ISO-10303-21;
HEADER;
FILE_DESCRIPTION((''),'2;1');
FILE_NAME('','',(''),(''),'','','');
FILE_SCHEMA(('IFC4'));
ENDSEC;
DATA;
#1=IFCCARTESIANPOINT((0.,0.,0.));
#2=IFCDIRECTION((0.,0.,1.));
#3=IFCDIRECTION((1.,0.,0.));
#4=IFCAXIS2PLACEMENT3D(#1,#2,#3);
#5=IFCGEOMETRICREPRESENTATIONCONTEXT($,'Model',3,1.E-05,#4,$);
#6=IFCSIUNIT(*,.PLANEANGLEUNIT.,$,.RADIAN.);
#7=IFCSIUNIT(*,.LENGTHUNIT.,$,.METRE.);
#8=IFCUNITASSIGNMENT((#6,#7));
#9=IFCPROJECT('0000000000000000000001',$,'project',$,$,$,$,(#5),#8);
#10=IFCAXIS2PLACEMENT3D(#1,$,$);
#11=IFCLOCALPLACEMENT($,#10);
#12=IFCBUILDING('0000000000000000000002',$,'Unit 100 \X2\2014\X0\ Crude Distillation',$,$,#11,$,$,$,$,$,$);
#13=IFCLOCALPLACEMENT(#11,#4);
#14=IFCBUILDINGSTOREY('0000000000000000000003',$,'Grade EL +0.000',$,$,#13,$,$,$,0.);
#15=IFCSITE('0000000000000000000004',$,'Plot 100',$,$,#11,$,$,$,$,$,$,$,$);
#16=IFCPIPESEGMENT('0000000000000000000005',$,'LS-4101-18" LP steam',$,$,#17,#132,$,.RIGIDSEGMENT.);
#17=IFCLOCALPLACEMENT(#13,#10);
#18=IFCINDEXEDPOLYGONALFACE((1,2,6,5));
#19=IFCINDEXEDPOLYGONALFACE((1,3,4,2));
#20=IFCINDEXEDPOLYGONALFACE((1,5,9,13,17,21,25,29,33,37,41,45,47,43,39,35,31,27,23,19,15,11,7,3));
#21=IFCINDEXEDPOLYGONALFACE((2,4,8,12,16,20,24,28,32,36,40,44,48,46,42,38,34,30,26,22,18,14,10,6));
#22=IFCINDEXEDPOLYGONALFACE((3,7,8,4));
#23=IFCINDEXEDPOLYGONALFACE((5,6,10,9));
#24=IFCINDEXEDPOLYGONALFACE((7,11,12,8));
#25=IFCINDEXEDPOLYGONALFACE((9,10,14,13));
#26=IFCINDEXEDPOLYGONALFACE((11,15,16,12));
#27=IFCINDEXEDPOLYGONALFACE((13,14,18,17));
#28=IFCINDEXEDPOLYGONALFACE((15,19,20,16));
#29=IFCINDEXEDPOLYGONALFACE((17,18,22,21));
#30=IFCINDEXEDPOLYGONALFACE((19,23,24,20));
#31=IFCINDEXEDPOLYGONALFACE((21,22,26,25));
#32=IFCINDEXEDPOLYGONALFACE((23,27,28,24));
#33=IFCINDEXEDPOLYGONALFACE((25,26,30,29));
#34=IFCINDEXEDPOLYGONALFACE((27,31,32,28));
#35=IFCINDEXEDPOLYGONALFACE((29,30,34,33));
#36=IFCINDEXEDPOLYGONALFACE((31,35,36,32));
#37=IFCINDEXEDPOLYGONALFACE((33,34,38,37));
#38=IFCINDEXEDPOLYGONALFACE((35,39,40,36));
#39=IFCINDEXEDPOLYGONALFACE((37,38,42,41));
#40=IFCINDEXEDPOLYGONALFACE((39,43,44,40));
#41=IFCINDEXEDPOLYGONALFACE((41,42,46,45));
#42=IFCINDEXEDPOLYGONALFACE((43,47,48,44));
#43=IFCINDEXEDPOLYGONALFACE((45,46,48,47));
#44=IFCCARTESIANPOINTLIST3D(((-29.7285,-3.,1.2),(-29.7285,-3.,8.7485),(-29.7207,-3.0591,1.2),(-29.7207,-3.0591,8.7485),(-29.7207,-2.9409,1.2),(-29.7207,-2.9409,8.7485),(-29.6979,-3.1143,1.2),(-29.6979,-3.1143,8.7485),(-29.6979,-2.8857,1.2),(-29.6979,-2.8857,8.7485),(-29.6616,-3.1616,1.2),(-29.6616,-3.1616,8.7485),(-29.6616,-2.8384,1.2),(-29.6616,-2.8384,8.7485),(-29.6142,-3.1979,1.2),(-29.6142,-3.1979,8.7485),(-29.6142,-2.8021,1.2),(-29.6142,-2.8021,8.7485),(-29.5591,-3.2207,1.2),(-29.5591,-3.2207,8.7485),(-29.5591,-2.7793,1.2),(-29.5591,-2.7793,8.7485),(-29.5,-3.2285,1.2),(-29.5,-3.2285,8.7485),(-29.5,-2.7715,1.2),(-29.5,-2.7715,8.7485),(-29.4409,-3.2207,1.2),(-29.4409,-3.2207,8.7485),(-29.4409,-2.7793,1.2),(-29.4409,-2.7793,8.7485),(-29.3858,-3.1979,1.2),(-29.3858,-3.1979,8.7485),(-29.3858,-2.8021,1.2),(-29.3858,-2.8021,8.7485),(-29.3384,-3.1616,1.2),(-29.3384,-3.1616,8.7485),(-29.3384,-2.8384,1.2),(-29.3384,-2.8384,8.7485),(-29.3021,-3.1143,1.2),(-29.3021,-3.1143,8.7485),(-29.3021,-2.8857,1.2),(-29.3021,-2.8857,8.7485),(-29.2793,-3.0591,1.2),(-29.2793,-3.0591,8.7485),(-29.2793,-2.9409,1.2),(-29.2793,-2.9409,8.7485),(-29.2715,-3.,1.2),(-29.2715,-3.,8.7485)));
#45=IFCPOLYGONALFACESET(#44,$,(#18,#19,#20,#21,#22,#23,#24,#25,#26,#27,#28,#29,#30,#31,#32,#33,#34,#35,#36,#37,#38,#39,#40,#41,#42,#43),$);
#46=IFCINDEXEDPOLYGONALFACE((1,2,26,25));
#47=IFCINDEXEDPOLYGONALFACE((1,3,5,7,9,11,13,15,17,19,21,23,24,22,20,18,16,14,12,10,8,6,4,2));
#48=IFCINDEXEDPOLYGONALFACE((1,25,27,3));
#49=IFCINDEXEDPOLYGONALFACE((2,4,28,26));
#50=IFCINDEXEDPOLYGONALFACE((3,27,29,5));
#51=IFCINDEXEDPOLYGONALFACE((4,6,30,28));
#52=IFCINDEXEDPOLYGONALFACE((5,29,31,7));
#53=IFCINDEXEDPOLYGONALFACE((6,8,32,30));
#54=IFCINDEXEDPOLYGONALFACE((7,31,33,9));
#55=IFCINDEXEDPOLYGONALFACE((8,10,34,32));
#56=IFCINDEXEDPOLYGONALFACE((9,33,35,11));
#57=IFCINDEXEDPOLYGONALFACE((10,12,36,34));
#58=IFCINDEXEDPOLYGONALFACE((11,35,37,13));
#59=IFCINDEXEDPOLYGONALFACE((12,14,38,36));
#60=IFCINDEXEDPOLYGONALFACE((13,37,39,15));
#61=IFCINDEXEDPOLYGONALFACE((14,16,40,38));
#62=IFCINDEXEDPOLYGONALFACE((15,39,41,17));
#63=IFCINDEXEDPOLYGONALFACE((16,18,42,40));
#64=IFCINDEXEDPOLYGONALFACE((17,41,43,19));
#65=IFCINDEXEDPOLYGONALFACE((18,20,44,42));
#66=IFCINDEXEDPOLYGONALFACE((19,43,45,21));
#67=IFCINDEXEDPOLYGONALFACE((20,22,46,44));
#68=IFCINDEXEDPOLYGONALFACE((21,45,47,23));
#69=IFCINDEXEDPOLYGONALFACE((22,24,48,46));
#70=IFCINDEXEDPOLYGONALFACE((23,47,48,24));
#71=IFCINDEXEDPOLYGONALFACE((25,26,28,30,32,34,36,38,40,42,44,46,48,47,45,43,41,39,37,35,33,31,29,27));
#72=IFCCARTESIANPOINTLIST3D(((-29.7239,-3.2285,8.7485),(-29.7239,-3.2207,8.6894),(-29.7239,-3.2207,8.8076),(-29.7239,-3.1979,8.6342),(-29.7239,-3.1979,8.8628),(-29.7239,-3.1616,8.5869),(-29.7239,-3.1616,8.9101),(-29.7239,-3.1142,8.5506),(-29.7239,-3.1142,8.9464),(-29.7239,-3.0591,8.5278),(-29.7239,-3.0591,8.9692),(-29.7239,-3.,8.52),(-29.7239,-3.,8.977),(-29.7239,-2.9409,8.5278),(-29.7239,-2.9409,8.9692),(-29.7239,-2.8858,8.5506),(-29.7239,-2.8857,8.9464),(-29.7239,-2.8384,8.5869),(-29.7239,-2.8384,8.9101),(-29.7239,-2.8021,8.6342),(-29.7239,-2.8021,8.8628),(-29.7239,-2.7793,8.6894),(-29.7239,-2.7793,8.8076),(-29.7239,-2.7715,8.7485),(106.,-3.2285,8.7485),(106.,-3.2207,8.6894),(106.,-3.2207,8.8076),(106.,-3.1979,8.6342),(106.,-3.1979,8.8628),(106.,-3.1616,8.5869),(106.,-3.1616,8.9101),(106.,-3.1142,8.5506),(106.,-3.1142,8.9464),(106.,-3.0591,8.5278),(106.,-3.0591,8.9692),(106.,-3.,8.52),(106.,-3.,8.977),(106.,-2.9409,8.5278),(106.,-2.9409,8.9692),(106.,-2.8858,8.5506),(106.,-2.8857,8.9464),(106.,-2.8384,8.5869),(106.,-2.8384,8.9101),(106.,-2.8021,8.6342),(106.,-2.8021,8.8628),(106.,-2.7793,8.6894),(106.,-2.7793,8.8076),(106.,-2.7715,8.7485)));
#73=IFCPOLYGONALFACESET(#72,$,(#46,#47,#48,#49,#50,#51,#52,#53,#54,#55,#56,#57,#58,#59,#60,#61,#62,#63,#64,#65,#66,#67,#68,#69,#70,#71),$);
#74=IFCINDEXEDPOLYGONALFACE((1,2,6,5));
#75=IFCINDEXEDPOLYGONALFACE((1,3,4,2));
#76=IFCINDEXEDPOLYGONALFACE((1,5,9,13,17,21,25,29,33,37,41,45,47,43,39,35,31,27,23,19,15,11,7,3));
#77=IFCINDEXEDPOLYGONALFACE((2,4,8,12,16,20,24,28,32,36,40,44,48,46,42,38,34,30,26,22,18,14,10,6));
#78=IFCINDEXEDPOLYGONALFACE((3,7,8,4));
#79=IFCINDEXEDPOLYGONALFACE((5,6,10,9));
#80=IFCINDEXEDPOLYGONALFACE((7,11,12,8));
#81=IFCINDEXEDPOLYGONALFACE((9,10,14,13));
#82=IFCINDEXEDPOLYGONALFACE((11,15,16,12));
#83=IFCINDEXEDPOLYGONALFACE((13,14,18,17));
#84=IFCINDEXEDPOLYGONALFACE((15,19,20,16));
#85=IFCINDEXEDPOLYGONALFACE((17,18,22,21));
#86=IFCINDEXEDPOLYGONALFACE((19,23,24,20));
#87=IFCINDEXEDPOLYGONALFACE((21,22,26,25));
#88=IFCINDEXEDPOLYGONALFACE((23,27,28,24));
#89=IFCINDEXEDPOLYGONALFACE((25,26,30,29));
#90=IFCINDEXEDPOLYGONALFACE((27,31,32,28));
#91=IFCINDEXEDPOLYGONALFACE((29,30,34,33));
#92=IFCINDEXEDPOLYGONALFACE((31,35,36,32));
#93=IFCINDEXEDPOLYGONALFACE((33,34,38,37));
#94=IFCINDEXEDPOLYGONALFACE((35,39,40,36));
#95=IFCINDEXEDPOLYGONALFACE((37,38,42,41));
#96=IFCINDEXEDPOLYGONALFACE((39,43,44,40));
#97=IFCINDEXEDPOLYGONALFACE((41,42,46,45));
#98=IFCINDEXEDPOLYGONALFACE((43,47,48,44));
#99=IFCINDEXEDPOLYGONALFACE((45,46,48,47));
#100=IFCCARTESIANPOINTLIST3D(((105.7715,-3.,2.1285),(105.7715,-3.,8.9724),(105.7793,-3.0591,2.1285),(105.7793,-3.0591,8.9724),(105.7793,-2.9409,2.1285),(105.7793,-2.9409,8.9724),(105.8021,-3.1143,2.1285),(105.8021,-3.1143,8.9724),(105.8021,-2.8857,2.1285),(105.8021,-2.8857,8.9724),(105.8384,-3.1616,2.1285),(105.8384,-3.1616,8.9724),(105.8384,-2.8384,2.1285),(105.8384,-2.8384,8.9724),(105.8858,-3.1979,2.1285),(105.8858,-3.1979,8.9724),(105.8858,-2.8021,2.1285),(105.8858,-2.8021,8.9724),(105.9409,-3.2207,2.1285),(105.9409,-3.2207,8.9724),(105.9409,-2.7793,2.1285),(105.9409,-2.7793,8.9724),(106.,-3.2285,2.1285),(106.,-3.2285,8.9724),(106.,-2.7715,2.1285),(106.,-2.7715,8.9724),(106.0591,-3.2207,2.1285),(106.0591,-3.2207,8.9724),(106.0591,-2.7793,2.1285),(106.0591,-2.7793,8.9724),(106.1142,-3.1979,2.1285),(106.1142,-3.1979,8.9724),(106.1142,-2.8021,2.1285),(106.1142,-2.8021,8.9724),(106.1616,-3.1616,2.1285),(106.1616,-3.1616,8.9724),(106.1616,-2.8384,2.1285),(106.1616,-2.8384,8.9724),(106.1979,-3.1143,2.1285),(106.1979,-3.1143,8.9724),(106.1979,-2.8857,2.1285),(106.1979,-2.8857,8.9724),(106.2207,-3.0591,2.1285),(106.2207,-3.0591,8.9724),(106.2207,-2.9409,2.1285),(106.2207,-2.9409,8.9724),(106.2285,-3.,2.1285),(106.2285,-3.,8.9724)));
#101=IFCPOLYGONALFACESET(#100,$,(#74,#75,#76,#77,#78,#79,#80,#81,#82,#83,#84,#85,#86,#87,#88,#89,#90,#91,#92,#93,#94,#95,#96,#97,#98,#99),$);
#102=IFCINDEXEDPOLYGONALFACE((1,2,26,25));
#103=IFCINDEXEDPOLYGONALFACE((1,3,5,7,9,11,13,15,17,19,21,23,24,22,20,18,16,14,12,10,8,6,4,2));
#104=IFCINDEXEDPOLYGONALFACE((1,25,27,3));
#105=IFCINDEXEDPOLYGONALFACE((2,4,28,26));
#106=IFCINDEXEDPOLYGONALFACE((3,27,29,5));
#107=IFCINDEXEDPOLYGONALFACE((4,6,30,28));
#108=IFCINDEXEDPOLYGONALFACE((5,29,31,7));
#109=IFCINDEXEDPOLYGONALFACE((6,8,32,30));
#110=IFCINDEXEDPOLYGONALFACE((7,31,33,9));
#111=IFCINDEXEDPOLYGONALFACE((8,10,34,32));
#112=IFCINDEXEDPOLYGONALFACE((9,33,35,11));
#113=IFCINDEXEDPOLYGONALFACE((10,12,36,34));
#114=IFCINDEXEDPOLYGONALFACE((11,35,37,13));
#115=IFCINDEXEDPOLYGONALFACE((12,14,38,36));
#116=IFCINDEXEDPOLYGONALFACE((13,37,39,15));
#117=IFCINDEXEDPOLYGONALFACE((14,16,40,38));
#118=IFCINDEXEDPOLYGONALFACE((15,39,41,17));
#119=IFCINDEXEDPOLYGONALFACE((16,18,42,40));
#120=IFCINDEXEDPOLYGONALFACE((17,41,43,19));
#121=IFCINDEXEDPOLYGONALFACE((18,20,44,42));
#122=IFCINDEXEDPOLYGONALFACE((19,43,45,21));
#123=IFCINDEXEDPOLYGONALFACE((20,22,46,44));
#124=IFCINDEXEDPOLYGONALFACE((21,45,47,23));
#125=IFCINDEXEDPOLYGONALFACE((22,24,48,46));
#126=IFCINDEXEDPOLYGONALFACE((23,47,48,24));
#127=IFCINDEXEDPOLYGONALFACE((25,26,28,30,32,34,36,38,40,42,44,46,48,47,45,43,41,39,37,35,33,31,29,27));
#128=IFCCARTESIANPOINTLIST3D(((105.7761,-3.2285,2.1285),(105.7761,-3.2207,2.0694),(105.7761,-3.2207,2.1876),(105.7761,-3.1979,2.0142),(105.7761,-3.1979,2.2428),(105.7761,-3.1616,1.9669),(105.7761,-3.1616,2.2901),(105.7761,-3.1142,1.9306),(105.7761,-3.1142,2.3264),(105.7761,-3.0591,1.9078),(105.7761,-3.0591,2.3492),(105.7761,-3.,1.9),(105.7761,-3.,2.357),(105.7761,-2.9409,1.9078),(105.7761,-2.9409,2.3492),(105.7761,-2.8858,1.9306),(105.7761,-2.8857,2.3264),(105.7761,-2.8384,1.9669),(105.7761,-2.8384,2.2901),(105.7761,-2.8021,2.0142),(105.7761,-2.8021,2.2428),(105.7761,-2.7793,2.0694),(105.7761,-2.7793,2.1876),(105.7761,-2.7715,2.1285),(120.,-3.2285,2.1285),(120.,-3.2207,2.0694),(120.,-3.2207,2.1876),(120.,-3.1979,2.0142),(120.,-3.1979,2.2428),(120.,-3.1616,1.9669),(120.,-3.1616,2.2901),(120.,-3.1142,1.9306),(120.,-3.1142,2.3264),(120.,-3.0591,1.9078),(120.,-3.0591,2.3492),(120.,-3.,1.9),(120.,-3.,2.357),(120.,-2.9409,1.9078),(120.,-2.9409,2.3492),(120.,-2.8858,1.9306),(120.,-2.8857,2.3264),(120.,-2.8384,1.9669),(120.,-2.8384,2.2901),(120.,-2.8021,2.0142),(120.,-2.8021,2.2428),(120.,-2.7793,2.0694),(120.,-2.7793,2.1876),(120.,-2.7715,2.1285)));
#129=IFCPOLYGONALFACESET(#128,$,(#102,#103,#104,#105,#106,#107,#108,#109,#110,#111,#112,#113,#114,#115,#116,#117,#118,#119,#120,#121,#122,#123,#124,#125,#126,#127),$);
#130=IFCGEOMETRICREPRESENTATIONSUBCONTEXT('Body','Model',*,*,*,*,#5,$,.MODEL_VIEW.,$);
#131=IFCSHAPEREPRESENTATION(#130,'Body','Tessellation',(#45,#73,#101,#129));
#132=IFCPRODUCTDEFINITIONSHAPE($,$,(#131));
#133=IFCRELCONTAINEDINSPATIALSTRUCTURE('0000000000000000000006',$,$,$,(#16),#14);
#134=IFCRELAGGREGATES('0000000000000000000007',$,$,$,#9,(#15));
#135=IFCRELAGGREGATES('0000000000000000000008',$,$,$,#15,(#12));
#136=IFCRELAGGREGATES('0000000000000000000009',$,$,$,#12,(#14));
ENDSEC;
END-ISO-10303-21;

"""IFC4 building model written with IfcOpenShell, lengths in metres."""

from ifc_helpers import new_model, si_unit, frame, origin, origin_with_axes, origin_2d, place, context, subcontext, project, spatial, circle, extrude, element, save


model = new_model("IFC4")

# Units and contexts
model_context = context("Model", 3, precision=1e-05, world=origin_with_axes())
body_context = subcontext(model_context, "Body", "Model", "MODEL_VIEW")
ifc_project = project(units=[si_unit("PLANEANGLEUNIT", "RADIAN"), si_unit("LENGTHUNIT", "METRE")], contexts=[model_context])

# Site, building, storey
placement = place(None, origin())
site = spatial("IfcSite", under=ifc_project, at=placement, Name="Plot 100")
building = spatial("IfcBuilding", under=site, at=placement, Name="Unit 100 — Crude Distillation")
storey_placement = place(placement, origin_with_axes())
storey = spatial("IfcBuildingStorey", under=building, at=storey_placement, Name="Grade EL +0.000", Elevation=0.0)

# Pipe segment
pipe_segment_1_placement = place(storey_placement, origin_with_axes())
element("IfcPipeSegment", 1, at=pipe_segment_1_placement, inside=storey, Name="LS-4101-18\" LP steam", PredefinedType="RIGIDSEGMENT", context=body_context, shape_type="SweptSolid", body=[
    extrude(circle(Radius=0.2285, at=origin_2d()), frame((-29.5, -3.0, 1.2), z_axis=(0.0, 0.0, 1.0), x_axis=(1.0, 0.0, 0.0)), (0.0, 0.0, 1.0), 7.5485),
    extrude(circle(Radius=0.2285, at=origin_2d()), frame((-29.7239, -3.0, 8.7485), z_axis=(1.0, 0.0, 0.0), x_axis=(0.0, 1.0, 0.0)), (0.0, 0.0, 1.0), 135.7239),
    extrude(circle(Radius=0.2285, at=origin_2d()), frame((106.0, -3.0, 8.9724), z_axis=(0.0, 0.0, -1.0), x_axis=(1.0, 0.0, 0.0)), (0.0, 0.0, 1.0), 6.8439),
    extrude(circle(Radius=0.2285, at=origin_2d()), frame((105.7761, -3.0, 2.1285), z_axis=(1.0, 0.0, 0.0), x_axis=(0.0, 1.0, 0.0)), (0.0, 0.0, 1.0), 14.2239),
])

save(model, "model.ifc")
